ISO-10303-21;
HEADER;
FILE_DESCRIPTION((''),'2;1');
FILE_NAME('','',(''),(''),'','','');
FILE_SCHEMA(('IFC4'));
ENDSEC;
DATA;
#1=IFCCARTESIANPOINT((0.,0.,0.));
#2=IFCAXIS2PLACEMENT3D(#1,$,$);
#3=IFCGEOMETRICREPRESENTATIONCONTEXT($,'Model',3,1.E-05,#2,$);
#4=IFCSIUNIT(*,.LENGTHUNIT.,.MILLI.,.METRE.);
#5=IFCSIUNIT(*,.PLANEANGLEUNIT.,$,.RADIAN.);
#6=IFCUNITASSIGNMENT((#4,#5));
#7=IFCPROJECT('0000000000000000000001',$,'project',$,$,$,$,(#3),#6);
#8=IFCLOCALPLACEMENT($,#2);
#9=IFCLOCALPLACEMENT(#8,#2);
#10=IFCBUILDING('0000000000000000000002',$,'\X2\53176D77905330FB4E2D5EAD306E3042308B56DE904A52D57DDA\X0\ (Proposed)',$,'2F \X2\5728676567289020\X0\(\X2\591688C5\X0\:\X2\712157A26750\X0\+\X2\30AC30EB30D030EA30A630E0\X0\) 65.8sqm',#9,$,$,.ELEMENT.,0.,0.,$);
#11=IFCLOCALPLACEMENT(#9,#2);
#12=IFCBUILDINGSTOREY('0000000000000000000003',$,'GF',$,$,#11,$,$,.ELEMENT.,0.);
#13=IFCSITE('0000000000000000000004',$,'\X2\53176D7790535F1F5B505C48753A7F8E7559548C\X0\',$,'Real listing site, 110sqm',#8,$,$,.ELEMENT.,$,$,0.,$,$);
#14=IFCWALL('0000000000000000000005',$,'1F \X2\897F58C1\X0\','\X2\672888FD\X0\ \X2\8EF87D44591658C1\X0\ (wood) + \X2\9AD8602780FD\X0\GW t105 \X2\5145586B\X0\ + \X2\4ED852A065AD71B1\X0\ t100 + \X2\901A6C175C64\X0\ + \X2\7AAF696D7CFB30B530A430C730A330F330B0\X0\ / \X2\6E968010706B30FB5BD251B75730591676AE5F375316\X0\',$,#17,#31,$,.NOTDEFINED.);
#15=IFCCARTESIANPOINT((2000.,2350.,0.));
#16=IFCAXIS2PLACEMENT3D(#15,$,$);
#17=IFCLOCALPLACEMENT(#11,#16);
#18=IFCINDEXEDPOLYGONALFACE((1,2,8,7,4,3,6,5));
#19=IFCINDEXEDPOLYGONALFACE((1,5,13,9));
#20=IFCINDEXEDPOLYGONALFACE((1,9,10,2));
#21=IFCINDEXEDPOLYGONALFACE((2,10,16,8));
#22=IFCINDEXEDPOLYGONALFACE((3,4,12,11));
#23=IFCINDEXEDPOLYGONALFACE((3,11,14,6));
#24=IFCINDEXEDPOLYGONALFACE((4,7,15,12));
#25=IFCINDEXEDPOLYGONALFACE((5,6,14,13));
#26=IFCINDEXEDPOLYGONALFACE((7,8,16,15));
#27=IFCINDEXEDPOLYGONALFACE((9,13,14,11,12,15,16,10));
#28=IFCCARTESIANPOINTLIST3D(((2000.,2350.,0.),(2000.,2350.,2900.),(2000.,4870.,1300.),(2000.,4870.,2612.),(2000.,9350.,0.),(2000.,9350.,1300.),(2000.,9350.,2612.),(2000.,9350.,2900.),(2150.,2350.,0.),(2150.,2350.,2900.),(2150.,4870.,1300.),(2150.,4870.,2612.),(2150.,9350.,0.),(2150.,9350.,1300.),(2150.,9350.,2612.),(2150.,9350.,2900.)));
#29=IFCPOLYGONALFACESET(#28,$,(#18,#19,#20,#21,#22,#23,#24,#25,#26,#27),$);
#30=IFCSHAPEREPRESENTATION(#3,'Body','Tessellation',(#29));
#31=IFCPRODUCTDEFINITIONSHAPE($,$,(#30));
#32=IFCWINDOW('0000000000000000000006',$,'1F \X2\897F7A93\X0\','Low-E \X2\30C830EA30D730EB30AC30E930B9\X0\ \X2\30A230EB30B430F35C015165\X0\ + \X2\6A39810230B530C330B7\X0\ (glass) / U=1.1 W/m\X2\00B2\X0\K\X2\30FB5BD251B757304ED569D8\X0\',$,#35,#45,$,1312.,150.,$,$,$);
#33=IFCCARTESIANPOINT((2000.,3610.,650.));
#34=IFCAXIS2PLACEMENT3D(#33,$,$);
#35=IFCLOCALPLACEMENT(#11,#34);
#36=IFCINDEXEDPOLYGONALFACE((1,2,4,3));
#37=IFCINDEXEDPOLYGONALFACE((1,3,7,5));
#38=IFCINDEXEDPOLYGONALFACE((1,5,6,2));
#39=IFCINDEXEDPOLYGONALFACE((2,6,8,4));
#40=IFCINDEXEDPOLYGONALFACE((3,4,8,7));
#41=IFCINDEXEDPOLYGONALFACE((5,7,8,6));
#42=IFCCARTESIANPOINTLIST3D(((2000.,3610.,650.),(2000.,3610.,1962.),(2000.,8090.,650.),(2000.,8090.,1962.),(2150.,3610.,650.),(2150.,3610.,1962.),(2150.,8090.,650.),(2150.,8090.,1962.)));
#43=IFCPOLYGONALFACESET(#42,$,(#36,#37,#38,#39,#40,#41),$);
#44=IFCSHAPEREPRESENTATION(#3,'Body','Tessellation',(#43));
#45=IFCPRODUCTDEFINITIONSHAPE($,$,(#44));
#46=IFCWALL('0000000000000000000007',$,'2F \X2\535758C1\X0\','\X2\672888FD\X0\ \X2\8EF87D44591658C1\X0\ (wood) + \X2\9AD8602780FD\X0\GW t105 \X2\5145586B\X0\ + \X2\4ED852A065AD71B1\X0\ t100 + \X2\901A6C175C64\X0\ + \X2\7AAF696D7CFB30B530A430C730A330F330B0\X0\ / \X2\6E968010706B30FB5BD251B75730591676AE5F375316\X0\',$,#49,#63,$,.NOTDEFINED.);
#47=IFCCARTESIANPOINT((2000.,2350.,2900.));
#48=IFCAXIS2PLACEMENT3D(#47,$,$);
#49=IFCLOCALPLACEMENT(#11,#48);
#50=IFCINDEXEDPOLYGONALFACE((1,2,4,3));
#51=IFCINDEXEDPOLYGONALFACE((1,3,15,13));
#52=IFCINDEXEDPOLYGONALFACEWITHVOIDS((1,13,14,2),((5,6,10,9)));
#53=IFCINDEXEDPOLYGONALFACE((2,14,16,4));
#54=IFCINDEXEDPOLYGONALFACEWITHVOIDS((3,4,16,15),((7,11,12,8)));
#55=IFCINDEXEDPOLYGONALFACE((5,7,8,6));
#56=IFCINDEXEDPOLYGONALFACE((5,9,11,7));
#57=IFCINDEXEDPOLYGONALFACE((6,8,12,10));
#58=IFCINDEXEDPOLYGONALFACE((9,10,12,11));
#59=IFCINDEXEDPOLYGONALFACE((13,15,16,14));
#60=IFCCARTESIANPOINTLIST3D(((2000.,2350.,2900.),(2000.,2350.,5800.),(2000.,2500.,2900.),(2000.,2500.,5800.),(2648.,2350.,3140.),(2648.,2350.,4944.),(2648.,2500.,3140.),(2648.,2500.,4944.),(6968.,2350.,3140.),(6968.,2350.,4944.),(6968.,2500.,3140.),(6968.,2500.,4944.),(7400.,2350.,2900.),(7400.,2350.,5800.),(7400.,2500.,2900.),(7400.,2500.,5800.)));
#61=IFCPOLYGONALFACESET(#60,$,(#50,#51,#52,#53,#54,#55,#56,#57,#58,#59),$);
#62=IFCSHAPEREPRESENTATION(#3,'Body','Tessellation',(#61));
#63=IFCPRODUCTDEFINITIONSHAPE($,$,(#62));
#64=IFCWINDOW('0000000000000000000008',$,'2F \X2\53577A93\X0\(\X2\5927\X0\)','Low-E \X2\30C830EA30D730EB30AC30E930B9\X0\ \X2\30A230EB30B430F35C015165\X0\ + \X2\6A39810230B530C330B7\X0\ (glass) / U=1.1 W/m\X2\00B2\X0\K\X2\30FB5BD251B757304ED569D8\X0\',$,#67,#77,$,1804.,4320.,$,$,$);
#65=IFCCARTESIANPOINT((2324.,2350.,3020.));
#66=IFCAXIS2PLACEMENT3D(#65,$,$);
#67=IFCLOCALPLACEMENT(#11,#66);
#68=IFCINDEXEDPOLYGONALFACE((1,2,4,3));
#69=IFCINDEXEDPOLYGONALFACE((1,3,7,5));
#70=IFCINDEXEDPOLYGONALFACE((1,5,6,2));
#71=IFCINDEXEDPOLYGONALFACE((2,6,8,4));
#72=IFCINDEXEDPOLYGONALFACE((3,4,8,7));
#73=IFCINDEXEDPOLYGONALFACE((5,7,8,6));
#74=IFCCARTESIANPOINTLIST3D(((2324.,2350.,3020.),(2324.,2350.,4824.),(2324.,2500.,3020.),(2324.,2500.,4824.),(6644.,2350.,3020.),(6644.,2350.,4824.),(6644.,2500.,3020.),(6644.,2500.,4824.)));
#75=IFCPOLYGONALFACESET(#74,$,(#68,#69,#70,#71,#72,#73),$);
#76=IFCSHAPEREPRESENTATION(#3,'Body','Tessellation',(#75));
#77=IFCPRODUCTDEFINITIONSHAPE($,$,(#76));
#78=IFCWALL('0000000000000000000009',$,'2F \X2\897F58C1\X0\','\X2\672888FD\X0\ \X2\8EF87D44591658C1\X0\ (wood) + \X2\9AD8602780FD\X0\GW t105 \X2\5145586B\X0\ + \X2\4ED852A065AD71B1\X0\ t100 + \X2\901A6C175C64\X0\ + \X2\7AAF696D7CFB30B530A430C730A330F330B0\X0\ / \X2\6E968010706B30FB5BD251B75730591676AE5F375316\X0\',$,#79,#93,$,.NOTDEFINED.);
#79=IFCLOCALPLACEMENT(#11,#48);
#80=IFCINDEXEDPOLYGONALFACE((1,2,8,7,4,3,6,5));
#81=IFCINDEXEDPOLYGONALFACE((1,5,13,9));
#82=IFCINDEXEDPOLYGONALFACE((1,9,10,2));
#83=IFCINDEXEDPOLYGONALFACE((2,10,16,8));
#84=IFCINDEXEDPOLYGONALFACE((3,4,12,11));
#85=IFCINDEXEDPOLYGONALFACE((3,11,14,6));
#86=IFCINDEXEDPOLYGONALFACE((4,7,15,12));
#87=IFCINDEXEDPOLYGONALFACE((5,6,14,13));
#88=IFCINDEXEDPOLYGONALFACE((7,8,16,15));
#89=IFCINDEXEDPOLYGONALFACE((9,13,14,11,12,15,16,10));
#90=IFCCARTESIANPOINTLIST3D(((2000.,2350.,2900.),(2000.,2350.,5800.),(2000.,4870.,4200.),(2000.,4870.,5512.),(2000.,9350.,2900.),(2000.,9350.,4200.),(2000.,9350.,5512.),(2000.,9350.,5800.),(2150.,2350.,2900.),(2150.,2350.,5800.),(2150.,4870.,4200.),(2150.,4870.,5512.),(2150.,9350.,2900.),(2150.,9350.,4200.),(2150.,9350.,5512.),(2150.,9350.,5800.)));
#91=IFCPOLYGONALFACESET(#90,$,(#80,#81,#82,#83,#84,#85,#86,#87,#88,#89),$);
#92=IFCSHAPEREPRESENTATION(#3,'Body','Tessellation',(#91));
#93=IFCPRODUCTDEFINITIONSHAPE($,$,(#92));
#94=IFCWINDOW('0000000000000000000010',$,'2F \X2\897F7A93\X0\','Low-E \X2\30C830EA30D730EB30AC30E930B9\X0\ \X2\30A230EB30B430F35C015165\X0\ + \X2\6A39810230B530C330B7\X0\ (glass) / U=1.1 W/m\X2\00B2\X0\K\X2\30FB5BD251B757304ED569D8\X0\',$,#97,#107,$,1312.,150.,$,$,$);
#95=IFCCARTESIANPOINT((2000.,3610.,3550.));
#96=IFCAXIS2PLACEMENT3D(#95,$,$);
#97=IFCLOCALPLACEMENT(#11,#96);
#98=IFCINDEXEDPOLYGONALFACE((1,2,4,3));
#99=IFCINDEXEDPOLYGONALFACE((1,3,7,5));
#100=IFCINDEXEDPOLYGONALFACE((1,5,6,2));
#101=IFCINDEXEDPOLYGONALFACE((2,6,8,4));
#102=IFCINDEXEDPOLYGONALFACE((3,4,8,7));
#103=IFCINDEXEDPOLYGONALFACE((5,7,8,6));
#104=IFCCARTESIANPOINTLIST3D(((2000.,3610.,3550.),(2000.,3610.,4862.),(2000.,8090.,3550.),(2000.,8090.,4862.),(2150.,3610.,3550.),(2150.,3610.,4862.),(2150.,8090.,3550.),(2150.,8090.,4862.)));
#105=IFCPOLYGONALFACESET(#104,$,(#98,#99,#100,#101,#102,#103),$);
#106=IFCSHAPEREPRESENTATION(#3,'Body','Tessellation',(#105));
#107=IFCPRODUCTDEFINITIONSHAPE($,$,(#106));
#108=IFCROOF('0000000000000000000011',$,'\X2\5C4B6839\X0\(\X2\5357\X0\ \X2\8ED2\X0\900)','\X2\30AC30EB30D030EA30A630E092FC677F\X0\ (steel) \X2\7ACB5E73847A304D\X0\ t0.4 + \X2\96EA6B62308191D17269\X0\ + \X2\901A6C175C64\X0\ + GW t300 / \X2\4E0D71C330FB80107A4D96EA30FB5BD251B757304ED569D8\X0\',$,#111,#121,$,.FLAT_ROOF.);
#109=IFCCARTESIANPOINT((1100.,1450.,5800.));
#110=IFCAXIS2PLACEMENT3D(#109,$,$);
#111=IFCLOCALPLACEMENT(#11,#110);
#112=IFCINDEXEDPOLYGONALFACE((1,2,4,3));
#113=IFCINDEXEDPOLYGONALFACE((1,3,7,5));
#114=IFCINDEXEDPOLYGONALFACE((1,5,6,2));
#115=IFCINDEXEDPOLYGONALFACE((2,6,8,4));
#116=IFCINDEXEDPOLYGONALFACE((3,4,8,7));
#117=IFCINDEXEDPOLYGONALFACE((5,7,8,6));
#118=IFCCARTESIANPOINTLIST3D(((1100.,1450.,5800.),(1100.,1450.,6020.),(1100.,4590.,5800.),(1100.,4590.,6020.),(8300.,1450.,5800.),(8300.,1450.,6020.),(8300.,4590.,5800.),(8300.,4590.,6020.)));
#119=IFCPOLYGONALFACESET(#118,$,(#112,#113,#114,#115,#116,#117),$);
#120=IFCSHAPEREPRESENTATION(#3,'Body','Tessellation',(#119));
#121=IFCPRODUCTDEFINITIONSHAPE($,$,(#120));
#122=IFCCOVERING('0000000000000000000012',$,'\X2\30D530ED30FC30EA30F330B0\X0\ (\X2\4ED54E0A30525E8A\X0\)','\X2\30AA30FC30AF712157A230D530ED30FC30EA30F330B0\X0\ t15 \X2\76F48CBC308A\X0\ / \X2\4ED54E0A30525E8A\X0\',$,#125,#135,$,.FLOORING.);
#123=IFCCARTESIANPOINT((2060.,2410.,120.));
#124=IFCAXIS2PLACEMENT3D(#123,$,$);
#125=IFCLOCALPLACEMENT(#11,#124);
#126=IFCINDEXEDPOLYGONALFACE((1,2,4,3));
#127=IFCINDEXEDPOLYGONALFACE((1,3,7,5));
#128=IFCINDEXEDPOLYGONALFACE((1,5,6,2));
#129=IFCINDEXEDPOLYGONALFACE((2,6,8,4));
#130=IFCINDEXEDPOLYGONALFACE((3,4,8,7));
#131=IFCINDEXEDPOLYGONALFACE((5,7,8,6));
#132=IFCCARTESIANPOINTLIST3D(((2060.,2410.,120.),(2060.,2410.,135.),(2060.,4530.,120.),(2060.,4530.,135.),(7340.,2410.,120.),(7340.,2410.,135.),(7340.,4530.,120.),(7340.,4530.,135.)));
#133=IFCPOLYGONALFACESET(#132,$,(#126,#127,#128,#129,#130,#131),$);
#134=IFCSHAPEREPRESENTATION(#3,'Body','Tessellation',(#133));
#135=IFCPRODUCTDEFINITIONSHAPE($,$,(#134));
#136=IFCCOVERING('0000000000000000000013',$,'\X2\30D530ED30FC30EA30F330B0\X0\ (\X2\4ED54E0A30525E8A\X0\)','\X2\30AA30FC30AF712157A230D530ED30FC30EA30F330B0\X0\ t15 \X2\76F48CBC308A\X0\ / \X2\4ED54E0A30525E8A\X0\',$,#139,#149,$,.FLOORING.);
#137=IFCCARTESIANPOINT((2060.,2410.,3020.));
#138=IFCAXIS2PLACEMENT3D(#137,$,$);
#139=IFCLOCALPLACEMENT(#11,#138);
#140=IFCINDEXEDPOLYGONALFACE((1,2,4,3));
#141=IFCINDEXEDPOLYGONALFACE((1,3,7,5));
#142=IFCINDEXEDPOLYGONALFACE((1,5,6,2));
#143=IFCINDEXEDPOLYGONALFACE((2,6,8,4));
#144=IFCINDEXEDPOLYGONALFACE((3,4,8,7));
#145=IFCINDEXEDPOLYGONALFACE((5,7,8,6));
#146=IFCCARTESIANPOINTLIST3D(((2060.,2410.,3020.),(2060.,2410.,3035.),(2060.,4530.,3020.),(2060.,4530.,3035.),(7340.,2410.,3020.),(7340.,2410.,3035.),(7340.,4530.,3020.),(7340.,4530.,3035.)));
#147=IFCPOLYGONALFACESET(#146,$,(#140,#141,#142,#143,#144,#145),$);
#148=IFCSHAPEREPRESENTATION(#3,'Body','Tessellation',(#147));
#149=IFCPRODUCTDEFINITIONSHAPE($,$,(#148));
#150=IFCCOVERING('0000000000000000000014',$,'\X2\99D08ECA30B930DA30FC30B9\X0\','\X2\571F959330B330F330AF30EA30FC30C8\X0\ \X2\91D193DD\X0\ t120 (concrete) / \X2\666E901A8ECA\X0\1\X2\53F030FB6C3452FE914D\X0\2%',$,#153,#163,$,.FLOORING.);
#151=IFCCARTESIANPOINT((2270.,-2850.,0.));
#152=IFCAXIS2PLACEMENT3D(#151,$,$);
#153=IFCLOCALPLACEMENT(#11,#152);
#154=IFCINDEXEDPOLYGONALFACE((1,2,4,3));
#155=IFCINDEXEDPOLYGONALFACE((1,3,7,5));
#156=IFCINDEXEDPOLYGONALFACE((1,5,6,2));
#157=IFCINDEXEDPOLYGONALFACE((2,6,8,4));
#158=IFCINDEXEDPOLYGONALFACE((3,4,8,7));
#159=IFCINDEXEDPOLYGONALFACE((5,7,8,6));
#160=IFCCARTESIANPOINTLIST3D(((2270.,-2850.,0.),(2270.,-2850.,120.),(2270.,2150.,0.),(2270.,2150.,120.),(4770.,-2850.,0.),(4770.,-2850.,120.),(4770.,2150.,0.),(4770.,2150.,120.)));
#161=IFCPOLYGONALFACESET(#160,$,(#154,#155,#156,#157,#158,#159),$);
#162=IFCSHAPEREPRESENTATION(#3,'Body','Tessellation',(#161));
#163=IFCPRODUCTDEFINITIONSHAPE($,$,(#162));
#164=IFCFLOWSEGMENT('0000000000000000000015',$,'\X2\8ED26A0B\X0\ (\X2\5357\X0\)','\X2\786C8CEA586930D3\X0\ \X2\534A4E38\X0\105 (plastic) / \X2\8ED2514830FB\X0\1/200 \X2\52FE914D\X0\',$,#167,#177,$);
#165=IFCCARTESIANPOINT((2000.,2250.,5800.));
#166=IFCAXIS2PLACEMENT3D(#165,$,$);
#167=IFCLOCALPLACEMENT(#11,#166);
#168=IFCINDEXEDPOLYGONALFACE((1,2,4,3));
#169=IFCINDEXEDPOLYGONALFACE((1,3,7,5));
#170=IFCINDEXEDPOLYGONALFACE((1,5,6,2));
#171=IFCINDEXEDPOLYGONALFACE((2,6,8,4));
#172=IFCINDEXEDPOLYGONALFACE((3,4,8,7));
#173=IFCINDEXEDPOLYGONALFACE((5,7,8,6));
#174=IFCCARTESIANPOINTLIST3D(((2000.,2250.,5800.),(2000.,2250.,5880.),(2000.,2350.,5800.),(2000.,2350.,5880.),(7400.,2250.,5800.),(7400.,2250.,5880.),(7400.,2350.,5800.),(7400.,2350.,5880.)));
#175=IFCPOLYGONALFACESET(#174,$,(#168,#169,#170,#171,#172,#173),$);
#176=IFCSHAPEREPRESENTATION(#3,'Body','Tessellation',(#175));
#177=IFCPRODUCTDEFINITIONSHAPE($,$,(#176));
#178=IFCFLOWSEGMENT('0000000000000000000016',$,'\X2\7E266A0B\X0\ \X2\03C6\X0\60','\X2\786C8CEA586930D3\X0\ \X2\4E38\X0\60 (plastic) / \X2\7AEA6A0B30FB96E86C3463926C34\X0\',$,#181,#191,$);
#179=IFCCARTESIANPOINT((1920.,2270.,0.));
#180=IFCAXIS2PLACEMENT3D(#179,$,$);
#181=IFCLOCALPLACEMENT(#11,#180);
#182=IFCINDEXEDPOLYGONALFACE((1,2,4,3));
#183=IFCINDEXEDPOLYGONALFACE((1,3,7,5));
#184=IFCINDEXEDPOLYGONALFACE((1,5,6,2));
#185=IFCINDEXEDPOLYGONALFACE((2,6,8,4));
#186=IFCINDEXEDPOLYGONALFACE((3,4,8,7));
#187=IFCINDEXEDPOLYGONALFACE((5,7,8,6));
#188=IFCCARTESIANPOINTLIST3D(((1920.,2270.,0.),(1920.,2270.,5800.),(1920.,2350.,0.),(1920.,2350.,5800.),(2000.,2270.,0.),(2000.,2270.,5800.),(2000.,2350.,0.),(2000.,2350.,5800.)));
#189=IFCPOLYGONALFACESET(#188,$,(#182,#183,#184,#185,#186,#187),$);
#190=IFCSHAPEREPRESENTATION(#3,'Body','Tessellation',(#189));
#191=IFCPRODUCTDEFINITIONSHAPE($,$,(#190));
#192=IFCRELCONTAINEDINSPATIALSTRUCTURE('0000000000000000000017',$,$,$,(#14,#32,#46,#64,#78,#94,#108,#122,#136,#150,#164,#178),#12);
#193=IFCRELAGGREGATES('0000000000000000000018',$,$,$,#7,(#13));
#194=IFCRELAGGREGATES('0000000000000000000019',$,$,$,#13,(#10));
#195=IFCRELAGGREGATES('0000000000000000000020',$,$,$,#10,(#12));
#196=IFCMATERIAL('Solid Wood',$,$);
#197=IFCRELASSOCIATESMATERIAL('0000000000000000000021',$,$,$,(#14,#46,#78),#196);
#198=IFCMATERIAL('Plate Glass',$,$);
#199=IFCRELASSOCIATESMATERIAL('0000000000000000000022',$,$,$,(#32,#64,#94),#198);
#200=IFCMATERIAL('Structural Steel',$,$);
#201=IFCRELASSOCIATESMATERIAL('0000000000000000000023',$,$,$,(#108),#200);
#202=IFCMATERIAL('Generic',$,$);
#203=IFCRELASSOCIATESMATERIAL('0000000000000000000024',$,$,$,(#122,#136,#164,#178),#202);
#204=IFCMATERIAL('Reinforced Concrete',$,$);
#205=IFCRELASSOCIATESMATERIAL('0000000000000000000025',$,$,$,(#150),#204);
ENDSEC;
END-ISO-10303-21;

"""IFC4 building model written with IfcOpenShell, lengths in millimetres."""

from ifc_helpers import new_model, si_unit, frame, frame_2d, origin, place, context, project, spatial, rectangle, extrude, material, element, fill, save


model = new_model("IFC4")

# Units and contexts
model_context = context("Model", 3, precision=1e-05, world=origin())
ifc_project = project(units=[si_unit("LENGTHUNIT", "METRE", prefix="MILLI"), si_unit("PLANEANGLEUNIT", "RADIAN")], contexts=[model_context])

# Site, building, storey
site_placement = place(None, origin())
site = spatial("IfcSite", under=ifc_project, at=site_placement, Name="北海道弟子屈町美留和", ObjectType="Real listing site, 110sqm", CompositionType="ELEMENT", RefElevation=0.0)
building_placement = place(site_placement, origin())
building = spatial("IfcBuilding", under=site, at=building_placement, Name="北海道・中庭のある回遊動線 (Proposed)", ObjectType="2F 在来木造(外装:無垢材+ガルバリウム) 65.8sqm", CompositionType="ELEMENT", ElevationOfRefHeight=0.0, ElevationOfTerrain=0.0)
storey_placement = place(building_placement, origin())
storey = spatial("IfcBuildingStorey", under=building, at=storey_placement, Name="GF", CompositionType="ELEMENT", Elevation=0.0)

# Shared definitions
ifc_material_1 = material(Name="Solid Wood")

# Shared definitions
ifc_material_2 = material(Name="Reinforced Concrete")

# Shared definitions
ifc_material_3 = material(Name="Plate Glass")

# Walls, openings, windows
wall_1_placement = place(storey_placement, frame((2000.0, 2350.0, 0.0)))
wall_1 = element("IfcWall", 1, at=wall_1_placement, inside=storey, material=ifc_material_1, Name="1F 西壁", Description="木製 軸組外壁 (wood) + 高性能GW t105 充填 + 付加断熱 t100 + 通気層 + 窯業系サイディング / 準耐火・寒冷地外皮強化", PredefinedType="NOTDEFINED", context=model_context, shape_type="SweptSolid", body=[
    extrude(rectangle(XDim=150.0, YDim=7000.0, at=frame_2d((75.0, 3500.0))), frame((2000.0, 2350.0, 0.0)), (0.0, 0.0, 1.0), 2900.0),
])
opening_1_placement = place(storey_placement, frame((2000.0, 3610.0, 650.0)))
opening_1 = element("IfcOpeningElement", 2, at=opening_1_placement, cuts=wall_1, PredefinedType="NOTDEFINED", context=model_context, shape_type="SweptSolid", body=[
    extrude(rectangle(XDim=150.0, YDim=4480.0, at=frame_2d((75.0, 2240.0))), frame((2000.0, 3610.0, 650.0)), (0.0, 0.0, 1.0), 1312.0),
])
window_1_placement = place(storey_placement, frame((2000.0, 3610.0, 650.0)))
window_1 = element("IfcWindow", 3, at=window_1_placement, inside=storey, material=ifc_material_3, Name="1F 西窓", Description="Low-E トリプルガラス アルゴン封入 + 樹脂サッシ (glass) / U=1.1 W/m²K・寒冷地仕様", OverallHeight=1312.0, OverallWidth=150.0, context=model_context, shape_type="SweptSolid", body=[
    extrude(rectangle(XDim=150.0, YDim=4480.0, at=frame_2d((75.0, 2240.0))), frame((2000.0, 3610.0, 650.0)), (0.0, 0.0, 1.0), 1312.0),
])
fill(opening_1, window_1)
wall_2_placement = place(storey_placement, frame((2000.0, 2350.0, 2900.0)))
wall_2 = element("IfcWall", 4, at=wall_2_placement, inside=storey, material=ifc_material_1, Name="2F 南壁", Description="木製 軸組外壁 (wood) + 高性能GW t105 充填 + 付加断熱 t100 + 通気層 + 窯業系サイディング / 準耐火・寒冷地外皮強化", PredefinedType="NOTDEFINED", context=model_context, shape_type="SweptSolid", body=[
    extrude(rectangle(XDim=5400.0, YDim=150.0, at=frame_2d((2700.0, 75.0))), frame((2000.0, 2350.0, 2900.0)), (0.0, 0.0, 1.0), 2900.0),
])
opening_2_placement = place(storey_placement, frame((2324.0, 2350.0, 3020.0)))
opening_2 = element("IfcOpeningElement", 5, at=opening_2_placement, cuts=wall_2, PredefinedType="NOTDEFINED", context=model_context, shape_type="SweptSolid", body=[
    extrude(rectangle(XDim=4320.0, YDim=150.0, at=frame_2d((2160.0, 75.0))), frame((2324.0, 2350.0, 3020.0)), (0.0, 0.0, 1.0), 1804.0),
])
window_2_placement = place(storey_placement, frame((2324.0, 2350.0, 3020.0)))
window_2 = element("IfcWindow", 6, at=window_2_placement, inside=storey, material=ifc_material_3, Name="2F 南窓(大)", Description="Low-E トリプルガラス アルゴン封入 + 樹脂サッシ (glass) / U=1.1 W/m²K・寒冷地仕様", OverallHeight=1804.0, OverallWidth=4320.0, context=model_context, shape_type="SweptSolid", body=[
    extrude(rectangle(XDim=4320.0, YDim=150.0, at=frame_2d((2160.0, 75.0))), frame((2324.0, 2350.0, 3020.0)), (0.0, 0.0, 1.0), 1804.0),
])
fill(opening_2, window_2)
wall_3_placement = place(storey_placement, frame((2000.0, 2350.0, 2900.0)))
wall_3 = element("IfcWall", 7, at=wall_3_placement, inside=storey, material=ifc_material_1, Name="2F 西壁", Description="木製 軸組外壁 (wood) + 高性能GW t105 充填 + 付加断熱 t100 + 通気層 + 窯業系サイディング / 準耐火・寒冷地外皮強化", PredefinedType="NOTDEFINED", context=model_context, shape_type="SweptSolid", body=[
    extrude(rectangle(XDim=150.0, YDim=7000.0, at=frame_2d((75.0, 3500.0))), frame((2000.0, 2350.0, 2900.0)), (0.0, 0.0, 1.0), 2900.0),
])
opening_3_placement = place(storey_placement, frame((2000.0, 3610.0, 3550.0)))
opening_3 = element("IfcOpeningElement", 8, at=opening_3_placement, cuts=wall_3, PredefinedType="NOTDEFINED", context=model_context, shape_type="SweptSolid", body=[
    extrude(rectangle(XDim=150.0, YDim=4480.0, at=frame_2d((75.0, 2240.0))), frame((2000.0, 3610.0, 3550.0)), (0.0, 0.0, 1.0), 1312.0),
])
window_3_placement = place(storey_placement, frame((2000.0, 3610.0, 3550.0)))
window_3 = element("IfcWindow", 9, at=window_3_placement, inside=storey, material=ifc_material_3, Name="2F 西窓", Description="Low-E トリプルガラス アルゴン封入 + 樹脂サッシ (glass) / U=1.1 W/m²K・寒冷地仕様", OverallHeight=1312.0, OverallWidth=150.0, context=model_context, shape_type="SweptSolid", body=[
    extrude(rectangle(XDim=150.0, YDim=4480.0, at=frame_2d((75.0, 2240.0))), frame((2000.0, 3610.0, 3550.0)), (0.0, 0.0, 1.0), 1312.0),
])
fill(opening_3, window_3)

# Roof
ifc_material_4 = material(Name="Structural Steel")
for number, where, name in (
    (10, (1100.0, 1450.0, 5800.0), "屋根(南 軒900)"),
):
    element("IfcRoof", number, at=place(storey_placement, frame(where)), inside=storey, material=ifc_material_4, Name=name, Description="ガルバリウム鋼板 (steel) 立平葺き t0.4 + 雪止め金物 + 通気層 + GW t300 / 不燃・耐積雪・寒冷地仕様", PredefinedType="FLAT_ROOF", context=model_context, shape_type="SweptSolid", body=[
        extrude(rectangle(XDim=7200.0, YDim=3140.0, at=frame_2d((3600.0, 1570.0))), frame((1100.0, 1450.0, 5800.0)), (0.0, 0.0, 1.0), 220.0),
    ])

# Coverings
ifc_material_5 = material(Name="Generic")
covering_1_placement = place(storey_placement, frame((2060.0, 2410.0, 120.0)))
element("IfcCovering", 11, at=covering_1_placement, inside=storey, material=ifc_material_5, Name="フローリング (仕上げ床)", Description="オーク無垢フローリング t15 直貼り / 仕上げ床", PredefinedType="FLOORING", context=model_context, shape_type="SweptSolid", body=[
    extrude(rectangle(XDim=5280.0, YDim=2120.0, at=frame_2d((2640.0, 1060.0))), frame((2060.0, 2410.0, 120.0)), (0.0, 0.0, 1.0), 15.0),
])
covering_2_placement = place(storey_placement, frame((2060.0, 2410.0, 3020.0)))
element("IfcCovering", 12, at=covering_2_placement, inside=storey, material=ifc_material_5, Name="フローリング (仕上げ床)", Description="オーク無垢フローリング t15 直貼り / 仕上げ床", PredefinedType="FLOORING", context=model_context, shape_type="SweptSolid", body=[
    extrude(rectangle(XDim=5280.0, YDim=2120.0, at=frame_2d((2640.0, 1060.0))), frame((2060.0, 2410.0, 3020.0)), (0.0, 0.0, 1.0), 15.0),
])
covering_3_placement = place(storey_placement, frame((2270.0, -2850.0, 0.0)))
element("IfcCovering", 13, at=covering_3_placement, inside=storey, material=ifc_material_2, Name="駐車スペース", Description="土間コンクリート 金鏝 t120 (concrete) / 普通車1台・水勾配2%", PredefinedType="FLOORING", context=model_context, shape_type="SweptSolid", body=[
    extrude(rectangle(XDim=2500.0, YDim=5000.0, at=frame_2d((1250.0, 2500.0))), frame((2270.0, -2850.0, 0.0)), (0.0, 0.0, 1.0), 120.0),
])

# Flow segments
flow_segment_1_placement = place(storey_placement, frame((2000.0, 2250.0, 5800.0)))
element("IfcFlowSegment", 14, at=flow_segment_1_placement, inside=storey, material=ifc_material_5, Name="軒樋 (南)", Description="硬質塩ビ 半丸105 (plastic) / 軒先・1/200 勾配", context=model_context, shape_type="SweptSolid", body=[
    extrude(rectangle(XDim=5400.0, YDim=100.0, at=frame_2d((2700.0, 50.0))), frame((2000.0, 2250.0, 5800.0)), (0.0, 0.0, 1.0), 80.0),
])
flow_segment_2_placement = place(storey_placement, frame((1920.0, 2270.0, 0.0)))
element("IfcFlowSegment", 15, at=flow_segment_2_placement, inside=storey, material=ifc_material_5, Name="縦樋 φ60", Description="硬質塩ビ 丸60 (plastic) / 竪樋・雨水排水", context=model_context, shape_type="SweptSolid", body=[
    extrude(rectangle(XDim=80.0, YDim=80.0, at=frame_2d((40.0, 40.0))), frame((1920.0, 2270.0, 0.0)), (0.0, 0.0, 1.0), 5800.0),
])

save(model, "model.ifc")
